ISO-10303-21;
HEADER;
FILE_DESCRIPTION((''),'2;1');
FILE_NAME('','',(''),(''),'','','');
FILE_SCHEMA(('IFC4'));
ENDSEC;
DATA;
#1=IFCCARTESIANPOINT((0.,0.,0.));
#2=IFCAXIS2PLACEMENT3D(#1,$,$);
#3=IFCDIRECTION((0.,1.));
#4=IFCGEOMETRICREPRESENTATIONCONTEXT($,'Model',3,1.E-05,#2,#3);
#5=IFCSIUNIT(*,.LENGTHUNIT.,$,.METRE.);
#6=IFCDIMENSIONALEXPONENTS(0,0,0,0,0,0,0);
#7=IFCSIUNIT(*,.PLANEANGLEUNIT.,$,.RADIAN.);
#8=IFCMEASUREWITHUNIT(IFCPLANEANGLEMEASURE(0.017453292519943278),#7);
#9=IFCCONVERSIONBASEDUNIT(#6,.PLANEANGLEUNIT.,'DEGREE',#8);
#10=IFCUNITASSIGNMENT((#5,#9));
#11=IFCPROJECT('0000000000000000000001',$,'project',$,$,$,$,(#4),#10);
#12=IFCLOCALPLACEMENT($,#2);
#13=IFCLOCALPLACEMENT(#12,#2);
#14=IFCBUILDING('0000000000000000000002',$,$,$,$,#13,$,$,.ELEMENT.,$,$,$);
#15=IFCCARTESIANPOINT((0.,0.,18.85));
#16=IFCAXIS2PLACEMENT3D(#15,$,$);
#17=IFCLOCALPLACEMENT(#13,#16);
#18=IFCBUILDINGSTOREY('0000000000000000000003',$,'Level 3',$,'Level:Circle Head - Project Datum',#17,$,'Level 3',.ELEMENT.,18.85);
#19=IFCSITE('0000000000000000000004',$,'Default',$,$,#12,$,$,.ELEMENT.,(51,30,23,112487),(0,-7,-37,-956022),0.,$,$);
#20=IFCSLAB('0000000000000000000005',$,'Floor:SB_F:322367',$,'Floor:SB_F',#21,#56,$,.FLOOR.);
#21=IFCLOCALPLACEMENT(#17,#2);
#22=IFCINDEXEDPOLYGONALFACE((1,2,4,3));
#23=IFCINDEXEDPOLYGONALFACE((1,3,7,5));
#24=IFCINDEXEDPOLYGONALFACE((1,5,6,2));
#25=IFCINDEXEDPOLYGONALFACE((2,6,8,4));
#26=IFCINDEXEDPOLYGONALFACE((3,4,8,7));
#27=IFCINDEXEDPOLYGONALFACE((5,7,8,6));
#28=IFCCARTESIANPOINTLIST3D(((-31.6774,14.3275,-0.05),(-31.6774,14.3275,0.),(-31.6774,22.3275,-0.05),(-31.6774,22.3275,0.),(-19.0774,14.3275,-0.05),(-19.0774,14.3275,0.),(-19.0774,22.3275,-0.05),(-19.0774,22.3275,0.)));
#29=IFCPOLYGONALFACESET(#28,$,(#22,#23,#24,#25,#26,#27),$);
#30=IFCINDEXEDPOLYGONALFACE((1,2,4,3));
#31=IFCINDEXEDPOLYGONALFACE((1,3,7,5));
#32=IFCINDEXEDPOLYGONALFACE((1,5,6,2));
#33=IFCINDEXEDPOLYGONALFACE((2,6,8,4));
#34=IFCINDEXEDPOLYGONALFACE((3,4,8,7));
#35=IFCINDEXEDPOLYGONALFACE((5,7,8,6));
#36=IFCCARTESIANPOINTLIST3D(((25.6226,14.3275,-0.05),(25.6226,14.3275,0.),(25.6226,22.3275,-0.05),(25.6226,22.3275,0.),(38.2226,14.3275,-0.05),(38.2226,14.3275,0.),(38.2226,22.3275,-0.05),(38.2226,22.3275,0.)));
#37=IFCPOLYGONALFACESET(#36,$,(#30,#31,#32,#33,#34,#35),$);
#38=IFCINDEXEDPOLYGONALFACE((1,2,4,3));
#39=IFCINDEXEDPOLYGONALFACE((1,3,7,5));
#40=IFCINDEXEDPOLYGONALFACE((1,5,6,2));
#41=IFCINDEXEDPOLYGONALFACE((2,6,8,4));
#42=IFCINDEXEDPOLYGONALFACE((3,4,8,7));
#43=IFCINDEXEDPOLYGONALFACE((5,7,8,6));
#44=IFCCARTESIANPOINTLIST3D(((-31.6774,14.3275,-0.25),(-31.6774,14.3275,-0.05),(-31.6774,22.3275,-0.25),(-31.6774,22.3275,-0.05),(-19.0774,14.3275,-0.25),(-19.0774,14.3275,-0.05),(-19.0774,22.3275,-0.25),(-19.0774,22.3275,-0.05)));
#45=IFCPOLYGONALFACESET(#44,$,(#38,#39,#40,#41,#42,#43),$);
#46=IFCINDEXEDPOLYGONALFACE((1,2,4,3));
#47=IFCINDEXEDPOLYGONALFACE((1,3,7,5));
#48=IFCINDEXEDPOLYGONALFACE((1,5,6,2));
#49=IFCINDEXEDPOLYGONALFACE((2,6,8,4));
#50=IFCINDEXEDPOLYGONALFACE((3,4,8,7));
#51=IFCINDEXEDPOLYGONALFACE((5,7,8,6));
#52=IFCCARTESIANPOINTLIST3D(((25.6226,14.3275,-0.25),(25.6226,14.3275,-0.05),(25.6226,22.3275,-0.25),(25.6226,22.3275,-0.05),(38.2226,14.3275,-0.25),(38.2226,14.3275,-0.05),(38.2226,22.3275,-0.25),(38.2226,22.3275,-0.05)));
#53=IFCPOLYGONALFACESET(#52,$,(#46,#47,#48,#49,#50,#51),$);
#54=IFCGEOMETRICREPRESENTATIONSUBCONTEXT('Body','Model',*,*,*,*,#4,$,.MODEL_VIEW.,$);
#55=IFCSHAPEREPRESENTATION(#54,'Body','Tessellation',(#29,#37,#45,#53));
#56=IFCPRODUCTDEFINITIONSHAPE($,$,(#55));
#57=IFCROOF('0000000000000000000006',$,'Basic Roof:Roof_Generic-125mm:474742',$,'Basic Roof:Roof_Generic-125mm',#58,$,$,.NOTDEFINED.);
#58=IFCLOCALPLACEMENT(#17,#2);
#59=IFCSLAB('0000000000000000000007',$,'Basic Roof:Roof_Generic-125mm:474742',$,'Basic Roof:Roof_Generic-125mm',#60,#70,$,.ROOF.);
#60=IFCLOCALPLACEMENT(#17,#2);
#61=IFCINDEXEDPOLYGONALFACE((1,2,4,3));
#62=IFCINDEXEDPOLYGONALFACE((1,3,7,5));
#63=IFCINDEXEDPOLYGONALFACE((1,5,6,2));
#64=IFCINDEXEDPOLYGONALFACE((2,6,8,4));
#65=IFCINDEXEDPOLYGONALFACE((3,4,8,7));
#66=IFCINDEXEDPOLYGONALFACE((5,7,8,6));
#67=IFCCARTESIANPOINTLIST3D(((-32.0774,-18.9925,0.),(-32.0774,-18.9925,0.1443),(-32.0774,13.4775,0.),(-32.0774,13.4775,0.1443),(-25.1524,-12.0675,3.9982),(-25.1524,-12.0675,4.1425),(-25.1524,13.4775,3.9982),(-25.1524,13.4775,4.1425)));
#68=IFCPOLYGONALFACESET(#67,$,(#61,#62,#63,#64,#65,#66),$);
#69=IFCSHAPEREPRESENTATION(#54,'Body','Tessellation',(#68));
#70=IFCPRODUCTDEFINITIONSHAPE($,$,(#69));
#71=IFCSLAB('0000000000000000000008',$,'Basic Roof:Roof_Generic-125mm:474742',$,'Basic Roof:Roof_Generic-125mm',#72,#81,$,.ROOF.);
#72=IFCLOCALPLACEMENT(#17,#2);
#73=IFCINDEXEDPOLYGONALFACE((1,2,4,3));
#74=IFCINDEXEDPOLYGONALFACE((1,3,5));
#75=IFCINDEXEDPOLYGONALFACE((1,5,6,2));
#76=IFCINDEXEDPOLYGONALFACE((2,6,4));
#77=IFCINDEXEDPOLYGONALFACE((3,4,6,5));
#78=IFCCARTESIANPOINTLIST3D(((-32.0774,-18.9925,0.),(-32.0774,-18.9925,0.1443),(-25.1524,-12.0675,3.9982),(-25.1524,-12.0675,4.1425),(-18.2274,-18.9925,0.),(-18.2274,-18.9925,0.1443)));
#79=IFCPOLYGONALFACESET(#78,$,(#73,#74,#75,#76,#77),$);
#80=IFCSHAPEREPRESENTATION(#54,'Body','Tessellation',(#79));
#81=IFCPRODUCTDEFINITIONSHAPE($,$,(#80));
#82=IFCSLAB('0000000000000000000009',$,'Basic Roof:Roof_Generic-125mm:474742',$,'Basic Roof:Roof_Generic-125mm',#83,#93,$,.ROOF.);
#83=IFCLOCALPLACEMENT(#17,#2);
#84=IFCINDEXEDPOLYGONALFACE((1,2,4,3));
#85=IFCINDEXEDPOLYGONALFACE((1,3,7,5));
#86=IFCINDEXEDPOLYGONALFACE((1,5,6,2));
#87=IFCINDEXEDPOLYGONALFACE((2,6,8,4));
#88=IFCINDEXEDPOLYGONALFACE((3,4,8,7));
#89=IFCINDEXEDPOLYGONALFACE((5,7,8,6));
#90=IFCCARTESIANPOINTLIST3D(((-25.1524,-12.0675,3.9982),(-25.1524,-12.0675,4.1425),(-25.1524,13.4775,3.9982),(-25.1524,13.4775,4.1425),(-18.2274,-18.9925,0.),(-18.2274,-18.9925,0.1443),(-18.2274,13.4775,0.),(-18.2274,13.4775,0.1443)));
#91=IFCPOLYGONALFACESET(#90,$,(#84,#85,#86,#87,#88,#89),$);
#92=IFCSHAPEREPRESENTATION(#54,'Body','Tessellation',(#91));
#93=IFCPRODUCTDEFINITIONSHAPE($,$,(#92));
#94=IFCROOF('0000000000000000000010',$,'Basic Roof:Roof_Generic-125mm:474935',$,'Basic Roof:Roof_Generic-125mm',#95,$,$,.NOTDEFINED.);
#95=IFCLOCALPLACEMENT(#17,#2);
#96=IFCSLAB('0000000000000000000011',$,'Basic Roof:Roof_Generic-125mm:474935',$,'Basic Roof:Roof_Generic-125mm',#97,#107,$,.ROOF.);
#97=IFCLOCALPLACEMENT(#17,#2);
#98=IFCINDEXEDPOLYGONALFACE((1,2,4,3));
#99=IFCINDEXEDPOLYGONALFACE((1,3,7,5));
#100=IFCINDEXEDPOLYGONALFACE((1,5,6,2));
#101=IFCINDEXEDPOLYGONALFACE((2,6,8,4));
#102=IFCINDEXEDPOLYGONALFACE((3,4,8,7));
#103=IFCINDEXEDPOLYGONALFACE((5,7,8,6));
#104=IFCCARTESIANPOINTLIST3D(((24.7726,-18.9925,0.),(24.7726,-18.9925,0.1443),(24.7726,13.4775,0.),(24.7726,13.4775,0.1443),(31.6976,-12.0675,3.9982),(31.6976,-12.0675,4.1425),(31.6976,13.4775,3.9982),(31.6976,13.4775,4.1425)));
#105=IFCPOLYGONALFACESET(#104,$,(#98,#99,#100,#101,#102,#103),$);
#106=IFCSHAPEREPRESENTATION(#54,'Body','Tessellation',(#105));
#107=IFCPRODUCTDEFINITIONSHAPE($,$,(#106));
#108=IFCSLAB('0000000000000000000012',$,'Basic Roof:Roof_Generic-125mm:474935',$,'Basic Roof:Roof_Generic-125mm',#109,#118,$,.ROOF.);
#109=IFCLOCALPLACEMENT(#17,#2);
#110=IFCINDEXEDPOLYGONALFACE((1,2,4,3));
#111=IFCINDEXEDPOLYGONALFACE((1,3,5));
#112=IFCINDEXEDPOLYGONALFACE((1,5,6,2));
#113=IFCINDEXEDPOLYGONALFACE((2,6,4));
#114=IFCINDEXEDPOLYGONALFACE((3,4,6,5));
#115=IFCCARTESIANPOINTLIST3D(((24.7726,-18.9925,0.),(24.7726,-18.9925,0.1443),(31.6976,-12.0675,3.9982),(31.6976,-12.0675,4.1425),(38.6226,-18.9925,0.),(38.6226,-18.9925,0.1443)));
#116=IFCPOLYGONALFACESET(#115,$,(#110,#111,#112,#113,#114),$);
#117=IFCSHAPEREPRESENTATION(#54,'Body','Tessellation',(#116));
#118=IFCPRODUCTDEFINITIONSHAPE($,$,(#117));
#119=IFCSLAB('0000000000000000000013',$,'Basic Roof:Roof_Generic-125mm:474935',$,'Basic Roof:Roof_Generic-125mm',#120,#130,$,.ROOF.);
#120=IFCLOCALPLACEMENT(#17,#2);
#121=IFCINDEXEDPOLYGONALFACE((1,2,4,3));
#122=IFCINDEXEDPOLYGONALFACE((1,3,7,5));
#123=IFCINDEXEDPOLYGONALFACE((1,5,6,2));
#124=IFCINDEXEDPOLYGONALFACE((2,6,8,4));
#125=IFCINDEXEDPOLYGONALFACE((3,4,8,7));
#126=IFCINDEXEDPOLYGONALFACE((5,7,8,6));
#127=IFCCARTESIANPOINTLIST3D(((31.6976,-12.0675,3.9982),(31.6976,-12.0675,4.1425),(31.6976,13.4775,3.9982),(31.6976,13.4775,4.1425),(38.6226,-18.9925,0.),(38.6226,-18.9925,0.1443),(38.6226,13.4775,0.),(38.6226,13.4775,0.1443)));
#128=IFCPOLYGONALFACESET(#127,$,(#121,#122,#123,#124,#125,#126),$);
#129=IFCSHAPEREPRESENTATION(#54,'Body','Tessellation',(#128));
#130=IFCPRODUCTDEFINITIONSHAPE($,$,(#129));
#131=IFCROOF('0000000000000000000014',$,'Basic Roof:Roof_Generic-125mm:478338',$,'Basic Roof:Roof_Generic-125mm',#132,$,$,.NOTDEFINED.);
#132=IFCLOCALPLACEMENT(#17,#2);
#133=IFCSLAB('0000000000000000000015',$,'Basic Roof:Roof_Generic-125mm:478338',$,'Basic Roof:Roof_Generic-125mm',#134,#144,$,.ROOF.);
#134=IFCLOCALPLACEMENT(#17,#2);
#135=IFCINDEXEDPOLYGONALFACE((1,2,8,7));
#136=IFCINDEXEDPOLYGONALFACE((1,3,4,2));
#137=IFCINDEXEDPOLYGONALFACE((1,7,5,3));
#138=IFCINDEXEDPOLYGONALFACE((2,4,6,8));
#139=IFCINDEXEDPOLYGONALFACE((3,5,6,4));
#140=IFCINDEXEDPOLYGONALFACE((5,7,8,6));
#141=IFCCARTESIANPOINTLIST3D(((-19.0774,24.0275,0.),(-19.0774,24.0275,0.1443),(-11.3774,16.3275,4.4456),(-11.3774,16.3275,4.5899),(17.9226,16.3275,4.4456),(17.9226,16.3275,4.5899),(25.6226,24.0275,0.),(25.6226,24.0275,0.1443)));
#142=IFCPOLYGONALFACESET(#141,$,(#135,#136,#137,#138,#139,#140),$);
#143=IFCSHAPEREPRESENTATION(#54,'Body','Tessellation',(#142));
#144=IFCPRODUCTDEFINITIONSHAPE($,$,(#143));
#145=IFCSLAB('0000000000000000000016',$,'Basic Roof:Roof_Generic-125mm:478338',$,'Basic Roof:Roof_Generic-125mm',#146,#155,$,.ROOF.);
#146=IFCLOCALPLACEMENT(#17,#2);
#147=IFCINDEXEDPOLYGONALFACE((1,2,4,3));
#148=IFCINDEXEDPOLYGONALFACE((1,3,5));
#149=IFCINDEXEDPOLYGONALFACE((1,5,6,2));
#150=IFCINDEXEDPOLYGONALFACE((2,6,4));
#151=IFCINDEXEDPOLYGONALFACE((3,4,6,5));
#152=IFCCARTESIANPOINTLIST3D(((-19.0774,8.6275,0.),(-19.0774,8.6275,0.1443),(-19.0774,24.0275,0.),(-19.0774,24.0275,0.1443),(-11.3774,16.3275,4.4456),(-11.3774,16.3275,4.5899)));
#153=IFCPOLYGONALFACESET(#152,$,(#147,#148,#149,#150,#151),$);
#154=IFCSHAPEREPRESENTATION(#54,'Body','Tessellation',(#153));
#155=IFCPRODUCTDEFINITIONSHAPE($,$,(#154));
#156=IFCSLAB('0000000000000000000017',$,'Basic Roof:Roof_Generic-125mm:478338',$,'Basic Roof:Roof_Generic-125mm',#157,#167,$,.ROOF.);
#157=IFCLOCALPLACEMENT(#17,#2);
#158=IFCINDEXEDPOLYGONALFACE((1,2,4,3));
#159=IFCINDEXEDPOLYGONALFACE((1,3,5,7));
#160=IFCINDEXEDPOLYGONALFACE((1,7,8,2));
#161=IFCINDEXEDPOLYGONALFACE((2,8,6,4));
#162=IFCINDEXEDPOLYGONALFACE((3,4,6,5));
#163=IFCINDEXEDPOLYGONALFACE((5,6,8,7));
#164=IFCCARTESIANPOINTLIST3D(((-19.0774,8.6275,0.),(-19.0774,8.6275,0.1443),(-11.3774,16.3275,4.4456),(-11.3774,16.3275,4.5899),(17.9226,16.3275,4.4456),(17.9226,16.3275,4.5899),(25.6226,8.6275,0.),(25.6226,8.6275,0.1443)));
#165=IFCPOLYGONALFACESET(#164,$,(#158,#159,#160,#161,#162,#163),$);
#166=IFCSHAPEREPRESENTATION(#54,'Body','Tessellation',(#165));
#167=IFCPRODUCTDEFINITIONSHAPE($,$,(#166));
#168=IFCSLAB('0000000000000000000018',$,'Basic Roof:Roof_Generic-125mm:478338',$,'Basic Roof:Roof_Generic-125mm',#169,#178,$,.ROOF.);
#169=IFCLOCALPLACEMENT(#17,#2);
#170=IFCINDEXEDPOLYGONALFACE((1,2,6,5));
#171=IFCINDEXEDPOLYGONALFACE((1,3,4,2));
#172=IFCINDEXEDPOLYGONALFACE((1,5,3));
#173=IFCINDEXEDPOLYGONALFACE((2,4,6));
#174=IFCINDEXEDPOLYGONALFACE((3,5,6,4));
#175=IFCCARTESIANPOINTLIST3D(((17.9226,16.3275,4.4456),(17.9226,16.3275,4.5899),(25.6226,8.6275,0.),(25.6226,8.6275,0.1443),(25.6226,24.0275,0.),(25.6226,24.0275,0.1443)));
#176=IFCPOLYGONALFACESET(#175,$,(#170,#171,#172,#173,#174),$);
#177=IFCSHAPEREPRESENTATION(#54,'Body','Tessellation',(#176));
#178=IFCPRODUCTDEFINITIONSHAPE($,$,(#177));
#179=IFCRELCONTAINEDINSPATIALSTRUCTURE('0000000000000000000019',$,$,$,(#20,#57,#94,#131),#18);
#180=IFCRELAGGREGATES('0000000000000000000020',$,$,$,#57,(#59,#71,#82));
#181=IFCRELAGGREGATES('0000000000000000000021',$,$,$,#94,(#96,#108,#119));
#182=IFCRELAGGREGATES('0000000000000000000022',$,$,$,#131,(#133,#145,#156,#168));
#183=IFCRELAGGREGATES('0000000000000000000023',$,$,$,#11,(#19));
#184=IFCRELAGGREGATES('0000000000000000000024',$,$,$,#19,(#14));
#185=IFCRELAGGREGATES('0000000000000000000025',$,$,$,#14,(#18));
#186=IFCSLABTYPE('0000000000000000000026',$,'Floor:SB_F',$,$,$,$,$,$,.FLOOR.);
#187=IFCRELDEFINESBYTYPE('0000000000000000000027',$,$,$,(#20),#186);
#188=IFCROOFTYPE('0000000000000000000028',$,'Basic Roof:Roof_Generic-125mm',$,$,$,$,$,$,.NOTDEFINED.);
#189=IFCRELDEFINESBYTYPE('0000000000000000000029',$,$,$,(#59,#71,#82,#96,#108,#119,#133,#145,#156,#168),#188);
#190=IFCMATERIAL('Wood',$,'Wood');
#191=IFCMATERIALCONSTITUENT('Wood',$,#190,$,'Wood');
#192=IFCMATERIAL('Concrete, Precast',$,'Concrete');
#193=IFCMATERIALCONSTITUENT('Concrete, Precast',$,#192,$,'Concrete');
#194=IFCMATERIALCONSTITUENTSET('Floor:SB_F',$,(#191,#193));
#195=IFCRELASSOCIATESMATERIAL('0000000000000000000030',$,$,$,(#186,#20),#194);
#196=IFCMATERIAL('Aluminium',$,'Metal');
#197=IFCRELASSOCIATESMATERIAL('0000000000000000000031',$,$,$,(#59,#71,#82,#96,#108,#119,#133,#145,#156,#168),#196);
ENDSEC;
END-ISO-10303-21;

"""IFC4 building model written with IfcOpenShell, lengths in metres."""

from ifc_helpers import new_model, entity, si_unit, converted_unit, direction, frame, origin, place, context, subcontext, project, spatial, indexed_curve, outline, extrude, material, constituent, constituent_set, type_object, element, aggregate, save


model = new_model("IFC4")

# Units and contexts
model_context = context("Model", 3, precision=1e-05, world=origin(), true_north=direction((0.0, 1.0)))
body_context = subcontext(model_context, "Body", "Model", "MODEL_VIEW")
ifc_project = project(units=[si_unit("LENGTHUNIT", "METRE"), converted_unit("PLANEANGLEUNIT", "DEGREE", entity("IfcPlaneAngleMeasure", 0.017453292519943278), si_unit("PLANEANGLEUNIT", "RADIAN"), dimensions=[0, 0, 0, 0, 0, 0, 0])], contexts=[model_context])

# Site, building, storey
site_placement = place(None, origin())
site = spatial("IfcSite", under=ifc_project, at=site_placement, Name="Default", CompositionType="ELEMENT", RefLatitude=(51, 30, 23, 112487), RefLongitude=(0, -7, -37, -956022), RefElevation=0.0)
building_placement = place(site_placement, origin())
building = spatial("IfcBuilding", under=site, at=building_placement, CompositionType="ELEMENT")
storey_placement = place(building_placement, frame((0.0, 0.0, 18.85)))
storey = spatial("IfcBuildingStorey", under=building, at=storey_placement, Name="Level 3", ObjectType="Level:Circle Head - Project Datum", LongName="Level 3", CompositionType="ELEMENT", Elevation=18.85)

# Slab
ifc_material_1 = material(Name="Wood", Category="Wood")
ifc_constituent_1 = constituent(ifc_material_1, Name="Wood", Category="Wood")
ifc_material_2 = material(Name="Concrete, Precast", Category="Concrete")
ifc_constituent_2 = constituent(ifc_material_2, Name="Concrete, Precast", Category="Concrete")
ifc_constituent_set_1 = constituent_set(constituents=[ifc_constituent_1, ifc_constituent_2], Name="Floor:SB_F")
slab_type = type_object("IfcSlabType", Name="Floor:SB_F", PredefinedType="FLOOR", material=ifc_constituent_set_1)
slab_1_placement = place(storey_placement, origin())
element("IfcSlab", 1, at=slab_1_placement, inside=storey, type_object=slab_type, material=ifc_constituent_set_1, Name="Floor:SB_F:322367", ObjectType="Floor:SB_F", PredefinedType="FLOOR", context=body_context, shape_type="SweptSolid", body=[
    extrude(outline(indexed_curve([(-6.3, -4.0), (6.3, -4.0), (6.3, 4.0), (-6.3, 4.0), (-6.3, -4.0)], self_intersect=False)), frame((-25.3774, 18.3275, -0.05), z_axis=(0.0, 0.0, 1.0), x_axis=(-1.0, 0.0, 0.0)), (0.0, 0.0, 1.0), 0.05),
    extrude(outline(indexed_curve([(-6.3, -4.0), (6.3, -4.0), (6.3, 4.0), (-6.3, 4.0), (-6.3, -4.0)], self_intersect=False)), frame((31.9226, 18.3275, -0.05), z_axis=(0.0, 0.0, 1.0), x_axis=(-1.0, 0.0, 0.0)), (0.0, 0.0, 1.0), 0.05),
    extrude(outline(indexed_curve([(-6.3, -4.0), (6.3, -4.0), (6.3, 4.0), (-6.3, 4.0), (-6.3, -4.0)], self_intersect=False)), frame((-25.3774, 18.3275, -0.25), z_axis=(0.0, 0.0, 1.0), x_axis=(-1.0, 0.0, 0.0)), (0.0, 0.0, 1.0), 0.2),
    extrude(outline(indexed_curve([(-6.3, -4.0), (6.3, -4.0), (6.3, 4.0), (-6.3, 4.0), (-6.3, -4.0)], self_intersect=False)), frame((31.9226, 18.3275, -0.25), z_axis=(0.0, 0.0, 1.0), x_axis=(-1.0, 0.0, 0.0)), (0.0, 0.0, 1.0), 0.2),
])

# Roofs, slabs
roof_1_placement = place(storey_placement, frame((-32.0774, -18.9925, 0.0)))
roof_1 = element("IfcRoof", 2, at=roof_1_placement, inside=storey, Name="Basic Roof:Roof_Generic-125mm:474742", ObjectType="Basic Roof:Roof_Generic-125mm", PredefinedType="NOTDEFINED")
ifc_material_3 = material(Name="Aluminium", Category="Metal")
roof_type = type_object("IfcRoofType", Name="Basic Roof:Roof_Generic-125mm", PredefinedType="NOTDEFINED")
slab_2_placement = place(roof_1_placement, origin())
slab_2 = element("IfcSlab", 3, at=slab_2_placement, type_object=roof_type, material=ifc_material_3, Name="Basic Roof:Roof_Generic-125mm:474742", ObjectType="Basic Roof:Roof_Generic-125mm", PredefinedType="ROOF", context=body_context, shape_type="SweptSolid", body=[
    extrude(outline(indexed_curve([(-3.9982, 16.235), (-3.9982, -16.235), (3.9982, -9.31), (3.9982, 16.235), (-3.9982, 16.235)], self_intersect=False)), frame((3.4625, 16.235, 1.9991), z_axis=(-0.5, 0.0, 0.866025), x_axis=(0.866025, 0.0, 0.5)), (0.5, 0.0, 0.866025), 0.1443),
])
slab_3_placement = place(roof_1_placement, origin())
slab_3 = element("IfcSlab", 4, at=slab_3_placement, type_object=roof_type, material=ifc_material_3, Name="Basic Roof:Roof_Generic-125mm:474742", ObjectType="Basic Roof:Roof_Generic-125mm", PredefinedType="ROOF", context=body_context, shape_type="SweptSolid", body=[
    extrude(outline(indexed_curve([(-6.925, -3.9982), (6.925, -3.9982), (0.0, 3.9982), (-6.925, -3.9982)], self_intersect=False)), frame((6.925, 3.4625, 1.9991), z_axis=(0.0, -0.5, 0.866025), x_axis=(1.0, 0.0, 0.0)), (0.0, 0.5, 0.866025), 0.1443),
])
slab_4_placement = place(roof_1_placement, origin())
slab_4 = element("IfcSlab", 5, at=slab_4_placement, type_object=roof_type, material=ifc_material_3, Name="Basic Roof:Roof_Generic-125mm:474742", ObjectType="Basic Roof:Roof_Generic-125mm", PredefinedType="ROOF", context=body_context, shape_type="SweptSolid", body=[
    extrude(outline(indexed_curve([(-3.9982, 16.235), (-3.9982, -9.31), (3.9982, -16.235), (3.9982, 16.235), (-3.9982, 16.235)], self_intersect=False)), frame((10.3875, 16.235, 1.9991), z_axis=(0.5, 0.0, 0.866025), x_axis=(0.866025, 0.0, -0.5)), (-0.5, 0.0, 0.866025), 0.1443),
])
aggregate(roof_1, [slab_2, slab_3, slab_4])
roof_2_placement = place(storey_placement, frame((24.7726, -18.9925, 0.0)))
roof_2 = element("IfcRoof", 6, at=roof_2_placement, inside=storey, Name="Basic Roof:Roof_Generic-125mm:474935", ObjectType="Basic Roof:Roof_Generic-125mm", PredefinedType="NOTDEFINED")
slab_5_placement = place(roof_2_placement, origin())
slab_5 = element("IfcSlab", 7, at=slab_5_placement, type_object=roof_type, material=ifc_material_3, Name="Basic Roof:Roof_Generic-125mm:474935", ObjectType="Basic Roof:Roof_Generic-125mm", PredefinedType="ROOF", context=body_context, shape_type="SweptSolid", body=[
    extrude(outline(indexed_curve([(-3.9982, 16.235), (-3.9982, -16.235), (3.9982, -9.31), (3.9982, 16.235), (-3.9982, 16.235)], self_intersect=False)), frame((3.4625, 16.235, 1.9991), z_axis=(-0.5, 0.0, 0.866025), x_axis=(0.866025, 0.0, 0.5)), (0.5, 0.0, 0.866025), 0.1443),
])
slab_6_placement = place(roof_2_placement, origin())
slab_6 = element("IfcSlab", 8, at=slab_6_placement, type_object=roof_type, material=ifc_material_3, Name="Basic Roof:Roof_Generic-125mm:474935", ObjectType="Basic Roof:Roof_Generic-125mm", PredefinedType="ROOF", context=body_context, shape_type="SweptSolid", body=[
    extrude(outline(indexed_curve([(-6.925, -3.9982), (6.925, -3.9982), (0.0, 3.9982), (-6.925, -3.9982)], self_intersect=False)), frame((6.925, 3.4625, 1.9991), z_axis=(0.0, -0.5, 0.866025), x_axis=(1.0, 0.0, 0.0)), (0.0, 0.5, 0.866025), 0.1443),
])
slab_7_placement = place(roof_2_placement, origin())
slab_7 = element("IfcSlab", 9, at=slab_7_placement, type_object=roof_type, material=ifc_material_3, Name="Basic Roof:Roof_Generic-125mm:474935", ObjectType="Basic Roof:Roof_Generic-125mm", PredefinedType="ROOF", context=body_context, shape_type="SweptSolid", body=[
    extrude(outline(indexed_curve([(-3.9982, 16.235), (-3.9982, -9.31), (3.9982, -16.235), (3.9982, 16.235), (-3.9982, 16.235)], self_intersect=False)), frame((10.3875, 16.235, 1.9991), z_axis=(0.5, 0.0, 0.866025), x_axis=(0.866025, 0.0, -0.5)), (-0.5, 0.0, 0.866025), 0.1443),
])
aggregate(roof_2, [slab_5, slab_6, slab_7])
roof_3_placement = place(storey_placement, frame((-19.0774, 8.6275, 0.0)))
roof_3 = element("IfcRoof", 10, at=roof_3_placement, inside=storey, Name="Basic Roof:Roof_Generic-125mm:478338", ObjectType="Basic Roof:Roof_Generic-125mm", PredefinedType="NOTDEFINED")
slab_8_placement = place(roof_3_placement, origin())
slab_8 = element("IfcSlab", 11, at=slab_8_placement, type_object=roof_type, material=ifc_material_3, Name="Basic Roof:Roof_Generic-125mm:478338", ObjectType="Basic Roof:Roof_Generic-125mm", PredefinedType="ROOF", context=body_context, shape_type="SweptSolid", body=[
    extrude(outline(indexed_curve([(22.35, 4.4456), (-22.35, 4.4456), (-14.65, -4.4456), (14.65, -4.4456), (22.35, 4.4456)], self_intersect=False)), frame((22.35, 11.55, 2.2228), z_axis=(0.0, 0.5, 0.866025), x_axis=(1.0, 0.0, 0.0)), (0.0, -0.5, 0.866025), 0.1443),
])
slab_9_placement = place(roof_3_placement, origin())
slab_9 = element("IfcSlab", 12, at=slab_9_placement, type_object=roof_type, material=ifc_material_3, Name="Basic Roof:Roof_Generic-125mm:478338", ObjectType="Basic Roof:Roof_Generic-125mm", PredefinedType="ROOF", context=body_context, shape_type="SweptSolid", body=[
    extrude(outline(indexed_curve([(-4.4456, 7.7), (-4.4456, -7.7), (4.4456, 0.0), (-4.4456, 7.7)], self_intersect=False)), frame((3.85, 7.7, 2.2228), z_axis=(-0.5, 0.0, 0.866025), x_axis=(0.866025, 0.0, 0.5)), (0.5, 0.0, 0.866025), 0.1443),
])
slab_10_placement = place(roof_3_placement, origin())
slab_10 = element("IfcSlab", 13, at=slab_10_placement, type_object=roof_type, material=ifc_material_3, Name="Basic Roof:Roof_Generic-125mm:478338", ObjectType="Basic Roof:Roof_Generic-125mm", PredefinedType="ROOF", context=body_context, shape_type="SweptSolid", body=[
    extrude(outline(indexed_curve([(-22.35, -4.4456), (22.35, -4.4456), (14.65, 4.4456), (-14.65, 4.4456), (-22.35, -4.4456)], self_intersect=False)), frame((22.35, 3.85, 2.2228), z_axis=(0.0, -0.5, 0.866025), x_axis=(1.0, 0.0, 0.0)), (0.0, 0.5, 0.866025), 0.1443),
])
slab_11_placement = place(roof_3_placement, origin())
slab_11 = element("IfcSlab", 14, at=slab_11_placement, type_object=roof_type, material=ifc_material_3, Name="Basic Roof:Roof_Generic-125mm:478338", ObjectType="Basic Roof:Roof_Generic-125mm", PredefinedType="ROOF", context=body_context, shape_type="SweptSolid", body=[
    extrude(outline(indexed_curve([(-4.4456, 0.0), (4.4456, -7.7), (4.4456, 7.7), (-4.4456, 0.0)], self_intersect=False)), frame((40.85, 7.7, 2.2228), z_axis=(0.5, 0.0, 0.866025), x_axis=(0.866025, 0.0, -0.5)), (-0.5, 0.0, 0.866025), 0.1443),
])
aggregate(roof_3, [slab_8, slab_9, slab_10, slab_11])

save(model, "model.ifc")
